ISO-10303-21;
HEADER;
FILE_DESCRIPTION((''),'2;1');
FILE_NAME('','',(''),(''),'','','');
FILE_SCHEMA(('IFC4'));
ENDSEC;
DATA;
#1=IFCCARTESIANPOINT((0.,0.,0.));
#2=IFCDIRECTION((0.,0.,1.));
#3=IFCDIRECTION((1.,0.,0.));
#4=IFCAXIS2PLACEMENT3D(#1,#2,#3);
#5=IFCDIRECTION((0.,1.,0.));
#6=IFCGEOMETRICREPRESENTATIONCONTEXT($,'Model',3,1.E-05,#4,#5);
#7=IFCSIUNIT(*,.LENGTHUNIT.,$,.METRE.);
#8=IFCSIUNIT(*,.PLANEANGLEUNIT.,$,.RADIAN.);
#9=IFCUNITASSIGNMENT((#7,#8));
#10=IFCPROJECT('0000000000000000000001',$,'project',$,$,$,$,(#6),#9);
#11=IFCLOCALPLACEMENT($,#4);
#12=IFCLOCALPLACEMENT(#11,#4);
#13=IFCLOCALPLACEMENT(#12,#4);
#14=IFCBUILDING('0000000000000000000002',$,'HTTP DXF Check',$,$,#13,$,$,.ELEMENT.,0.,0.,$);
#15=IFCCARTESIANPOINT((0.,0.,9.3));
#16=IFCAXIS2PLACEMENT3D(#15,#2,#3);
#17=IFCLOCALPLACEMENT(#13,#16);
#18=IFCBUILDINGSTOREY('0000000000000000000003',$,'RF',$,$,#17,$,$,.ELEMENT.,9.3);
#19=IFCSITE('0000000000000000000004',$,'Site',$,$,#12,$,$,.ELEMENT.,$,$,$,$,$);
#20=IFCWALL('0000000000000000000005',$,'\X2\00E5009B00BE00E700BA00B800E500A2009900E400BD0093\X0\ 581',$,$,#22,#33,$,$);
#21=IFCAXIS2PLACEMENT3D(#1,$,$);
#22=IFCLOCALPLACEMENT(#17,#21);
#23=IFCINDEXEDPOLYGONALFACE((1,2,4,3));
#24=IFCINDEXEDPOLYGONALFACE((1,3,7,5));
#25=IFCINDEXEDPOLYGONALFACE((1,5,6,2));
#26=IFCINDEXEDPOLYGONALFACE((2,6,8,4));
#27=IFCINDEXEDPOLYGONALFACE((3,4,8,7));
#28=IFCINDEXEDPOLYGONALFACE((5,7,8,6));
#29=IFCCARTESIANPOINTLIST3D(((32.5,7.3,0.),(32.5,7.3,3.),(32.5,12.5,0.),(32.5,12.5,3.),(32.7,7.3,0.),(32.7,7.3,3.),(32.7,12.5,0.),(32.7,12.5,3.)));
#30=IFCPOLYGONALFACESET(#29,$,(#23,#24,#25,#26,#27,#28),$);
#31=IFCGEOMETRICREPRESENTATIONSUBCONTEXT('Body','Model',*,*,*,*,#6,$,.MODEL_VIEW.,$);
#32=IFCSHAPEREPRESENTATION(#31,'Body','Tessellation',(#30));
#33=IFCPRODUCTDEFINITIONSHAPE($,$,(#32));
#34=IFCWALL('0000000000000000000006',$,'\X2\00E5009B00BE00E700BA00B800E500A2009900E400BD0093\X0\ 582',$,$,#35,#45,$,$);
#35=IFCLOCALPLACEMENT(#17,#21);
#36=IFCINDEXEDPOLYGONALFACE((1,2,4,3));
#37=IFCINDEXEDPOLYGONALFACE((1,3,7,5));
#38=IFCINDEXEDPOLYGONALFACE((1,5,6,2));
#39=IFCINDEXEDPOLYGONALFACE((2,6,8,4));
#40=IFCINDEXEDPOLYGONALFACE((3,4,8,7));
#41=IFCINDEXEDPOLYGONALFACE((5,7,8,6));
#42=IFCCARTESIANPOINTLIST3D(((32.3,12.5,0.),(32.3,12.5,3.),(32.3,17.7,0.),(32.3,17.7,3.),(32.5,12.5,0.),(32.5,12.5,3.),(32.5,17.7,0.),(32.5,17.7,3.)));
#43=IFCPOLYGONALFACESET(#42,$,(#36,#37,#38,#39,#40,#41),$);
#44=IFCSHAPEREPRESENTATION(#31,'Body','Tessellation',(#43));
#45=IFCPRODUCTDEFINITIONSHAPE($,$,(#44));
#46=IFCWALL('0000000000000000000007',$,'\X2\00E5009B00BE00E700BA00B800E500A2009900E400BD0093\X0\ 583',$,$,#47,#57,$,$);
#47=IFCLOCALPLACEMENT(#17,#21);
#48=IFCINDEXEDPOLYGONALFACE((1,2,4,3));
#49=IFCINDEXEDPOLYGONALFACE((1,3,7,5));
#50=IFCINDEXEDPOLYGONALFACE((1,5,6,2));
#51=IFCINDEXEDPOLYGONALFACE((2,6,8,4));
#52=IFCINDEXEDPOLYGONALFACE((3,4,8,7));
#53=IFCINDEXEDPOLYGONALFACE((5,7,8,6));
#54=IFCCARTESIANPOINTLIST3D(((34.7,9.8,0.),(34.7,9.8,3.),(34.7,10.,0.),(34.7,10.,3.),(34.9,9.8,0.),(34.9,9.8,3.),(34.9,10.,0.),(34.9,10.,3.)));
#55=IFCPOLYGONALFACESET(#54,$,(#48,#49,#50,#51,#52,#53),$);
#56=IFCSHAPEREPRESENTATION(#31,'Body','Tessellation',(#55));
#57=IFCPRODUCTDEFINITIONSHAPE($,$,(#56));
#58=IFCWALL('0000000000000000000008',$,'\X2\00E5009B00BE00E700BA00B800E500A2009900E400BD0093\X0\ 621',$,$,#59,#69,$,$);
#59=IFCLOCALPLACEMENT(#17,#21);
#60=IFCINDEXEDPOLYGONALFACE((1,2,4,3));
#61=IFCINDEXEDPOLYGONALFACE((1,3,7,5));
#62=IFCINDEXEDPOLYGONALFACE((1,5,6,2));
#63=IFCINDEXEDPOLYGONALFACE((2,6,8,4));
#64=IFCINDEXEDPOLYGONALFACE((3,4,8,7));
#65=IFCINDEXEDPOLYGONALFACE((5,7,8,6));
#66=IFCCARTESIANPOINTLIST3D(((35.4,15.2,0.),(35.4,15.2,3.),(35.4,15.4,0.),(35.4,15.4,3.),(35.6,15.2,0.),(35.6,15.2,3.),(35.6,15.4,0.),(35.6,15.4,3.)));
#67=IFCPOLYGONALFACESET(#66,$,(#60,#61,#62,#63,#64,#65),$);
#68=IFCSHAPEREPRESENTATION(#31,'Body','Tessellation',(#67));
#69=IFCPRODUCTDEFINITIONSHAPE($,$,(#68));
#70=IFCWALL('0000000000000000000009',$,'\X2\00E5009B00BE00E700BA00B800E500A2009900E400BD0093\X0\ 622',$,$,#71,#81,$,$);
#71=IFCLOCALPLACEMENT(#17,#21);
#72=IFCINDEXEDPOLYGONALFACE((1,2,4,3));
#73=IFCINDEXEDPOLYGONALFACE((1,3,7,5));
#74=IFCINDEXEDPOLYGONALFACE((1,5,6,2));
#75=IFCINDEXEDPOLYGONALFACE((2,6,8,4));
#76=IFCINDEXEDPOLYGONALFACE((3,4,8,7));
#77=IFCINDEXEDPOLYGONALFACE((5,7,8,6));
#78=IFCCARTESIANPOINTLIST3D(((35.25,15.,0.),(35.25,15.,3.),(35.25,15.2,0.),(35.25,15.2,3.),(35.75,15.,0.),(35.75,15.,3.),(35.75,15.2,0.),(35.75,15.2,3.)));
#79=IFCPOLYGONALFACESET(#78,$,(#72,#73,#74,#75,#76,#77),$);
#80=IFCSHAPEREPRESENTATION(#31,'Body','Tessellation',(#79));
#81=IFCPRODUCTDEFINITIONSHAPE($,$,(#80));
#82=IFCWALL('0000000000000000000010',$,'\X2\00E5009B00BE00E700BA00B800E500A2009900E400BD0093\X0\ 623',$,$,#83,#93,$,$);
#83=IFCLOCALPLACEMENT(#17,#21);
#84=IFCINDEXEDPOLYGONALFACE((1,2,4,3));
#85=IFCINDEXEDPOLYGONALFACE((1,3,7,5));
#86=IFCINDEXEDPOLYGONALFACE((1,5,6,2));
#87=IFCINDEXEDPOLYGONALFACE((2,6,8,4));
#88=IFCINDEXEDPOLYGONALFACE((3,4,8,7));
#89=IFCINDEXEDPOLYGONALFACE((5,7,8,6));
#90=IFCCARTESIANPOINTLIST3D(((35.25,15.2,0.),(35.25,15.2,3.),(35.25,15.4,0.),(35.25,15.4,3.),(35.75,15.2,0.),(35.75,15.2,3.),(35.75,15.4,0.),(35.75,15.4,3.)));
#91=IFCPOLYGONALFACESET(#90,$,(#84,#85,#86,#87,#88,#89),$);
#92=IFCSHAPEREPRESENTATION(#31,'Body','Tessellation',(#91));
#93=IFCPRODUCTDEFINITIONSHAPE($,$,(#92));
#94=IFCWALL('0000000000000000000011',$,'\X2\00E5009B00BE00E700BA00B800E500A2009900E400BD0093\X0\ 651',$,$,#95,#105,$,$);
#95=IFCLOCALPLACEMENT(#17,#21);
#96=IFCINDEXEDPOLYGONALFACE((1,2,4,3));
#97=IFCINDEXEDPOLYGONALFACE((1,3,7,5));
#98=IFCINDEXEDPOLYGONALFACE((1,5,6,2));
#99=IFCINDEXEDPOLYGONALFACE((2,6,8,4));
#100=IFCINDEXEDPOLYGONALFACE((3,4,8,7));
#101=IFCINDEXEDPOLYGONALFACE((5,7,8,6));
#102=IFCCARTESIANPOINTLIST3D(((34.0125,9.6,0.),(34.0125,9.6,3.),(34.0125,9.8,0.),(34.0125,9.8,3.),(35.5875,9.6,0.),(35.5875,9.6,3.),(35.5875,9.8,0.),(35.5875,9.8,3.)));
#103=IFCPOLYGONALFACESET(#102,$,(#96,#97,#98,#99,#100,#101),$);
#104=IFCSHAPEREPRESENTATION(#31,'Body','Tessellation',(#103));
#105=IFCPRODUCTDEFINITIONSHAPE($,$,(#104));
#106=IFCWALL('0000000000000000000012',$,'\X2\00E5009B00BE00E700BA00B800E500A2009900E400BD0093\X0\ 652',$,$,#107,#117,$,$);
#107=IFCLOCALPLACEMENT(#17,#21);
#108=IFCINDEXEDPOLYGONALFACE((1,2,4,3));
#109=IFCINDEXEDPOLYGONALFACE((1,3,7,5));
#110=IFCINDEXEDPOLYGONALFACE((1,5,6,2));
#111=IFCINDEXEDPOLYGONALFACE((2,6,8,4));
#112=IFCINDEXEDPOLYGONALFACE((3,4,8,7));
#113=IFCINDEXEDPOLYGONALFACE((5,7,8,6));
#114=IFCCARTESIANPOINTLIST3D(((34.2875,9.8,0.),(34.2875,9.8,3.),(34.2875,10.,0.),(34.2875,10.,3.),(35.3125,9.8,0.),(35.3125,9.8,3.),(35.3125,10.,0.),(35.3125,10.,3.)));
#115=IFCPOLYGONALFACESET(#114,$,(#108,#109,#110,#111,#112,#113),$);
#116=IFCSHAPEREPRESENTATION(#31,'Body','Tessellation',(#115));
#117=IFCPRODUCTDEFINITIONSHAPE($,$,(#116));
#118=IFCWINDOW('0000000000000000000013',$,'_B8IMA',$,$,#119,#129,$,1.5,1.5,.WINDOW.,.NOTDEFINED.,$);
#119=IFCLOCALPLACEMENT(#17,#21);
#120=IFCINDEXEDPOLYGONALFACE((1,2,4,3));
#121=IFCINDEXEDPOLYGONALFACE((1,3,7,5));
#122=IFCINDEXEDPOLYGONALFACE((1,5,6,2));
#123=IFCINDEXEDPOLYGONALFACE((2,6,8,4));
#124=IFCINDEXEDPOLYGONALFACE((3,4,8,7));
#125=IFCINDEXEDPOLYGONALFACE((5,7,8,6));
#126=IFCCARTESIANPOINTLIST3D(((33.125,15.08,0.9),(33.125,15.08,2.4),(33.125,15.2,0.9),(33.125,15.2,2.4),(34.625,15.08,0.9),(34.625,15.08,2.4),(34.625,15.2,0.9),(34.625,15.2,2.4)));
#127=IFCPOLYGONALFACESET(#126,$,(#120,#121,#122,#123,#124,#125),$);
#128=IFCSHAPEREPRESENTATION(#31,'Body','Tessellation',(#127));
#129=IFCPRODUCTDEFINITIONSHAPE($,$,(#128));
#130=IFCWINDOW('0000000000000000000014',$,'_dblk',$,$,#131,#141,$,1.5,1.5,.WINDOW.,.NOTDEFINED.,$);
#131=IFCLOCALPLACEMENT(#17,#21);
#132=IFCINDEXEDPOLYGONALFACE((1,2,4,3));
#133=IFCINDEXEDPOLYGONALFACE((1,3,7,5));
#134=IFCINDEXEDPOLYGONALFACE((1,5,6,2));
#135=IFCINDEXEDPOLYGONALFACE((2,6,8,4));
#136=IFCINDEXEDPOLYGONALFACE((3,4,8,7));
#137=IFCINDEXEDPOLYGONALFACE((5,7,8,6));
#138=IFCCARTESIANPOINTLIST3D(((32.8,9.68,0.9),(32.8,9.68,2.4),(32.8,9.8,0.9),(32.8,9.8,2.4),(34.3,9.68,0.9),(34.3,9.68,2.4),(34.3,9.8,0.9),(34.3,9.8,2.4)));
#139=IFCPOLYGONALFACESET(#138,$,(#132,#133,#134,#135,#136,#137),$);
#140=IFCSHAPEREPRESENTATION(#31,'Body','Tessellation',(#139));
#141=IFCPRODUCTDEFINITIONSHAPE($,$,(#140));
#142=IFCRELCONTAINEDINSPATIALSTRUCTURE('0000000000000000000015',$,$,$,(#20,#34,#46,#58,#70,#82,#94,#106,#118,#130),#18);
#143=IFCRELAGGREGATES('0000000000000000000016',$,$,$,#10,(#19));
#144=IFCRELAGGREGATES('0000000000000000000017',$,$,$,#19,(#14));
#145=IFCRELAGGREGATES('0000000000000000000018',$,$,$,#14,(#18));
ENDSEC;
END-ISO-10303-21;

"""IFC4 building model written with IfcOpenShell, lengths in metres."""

from ifc_helpers import new_model, si_unit, direction, frame, frame_2d, origin_with_axes, place, context, subcontext, project, spatial, rectangle, extrude, element, save


model = new_model("IFC4")

# Units and contexts
model_context = context("Model", 3, precision=1e-05, world=origin_with_axes(), true_north=direction((0.0, 1.0, 0.0)))
body_context = subcontext(model_context, "Body", "Model", "MODEL_VIEW")
ifc_project = project(units=[si_unit("LENGTHUNIT", "METRE"), si_unit("PLANEANGLEUNIT", "RADIAN")], contexts=[model_context])

# Site, building, storey
placement = place(None, origin_with_axes())
site_placement = place(placement, origin_with_axes())
site = spatial("IfcSite", under=ifc_project, at=site_placement, Name="Site", CompositionType="ELEMENT")
building_placement = place(site_placement, origin_with_axes())
building = spatial("IfcBuilding", under=site, at=building_placement, Name="HTTP DXF Check", CompositionType="ELEMENT", ElevationOfRefHeight=0.0, ElevationOfTerrain=0.0)
storey_placement = place(building_placement, frame((0.0, 0.0, 9.3), z_axis=(0.0, 0.0, 1.0), x_axis=(1.0, 0.0, 0.0)))
storey = spatial("IfcBuildingStorey", under=building, at=storey_placement, Name="RF", CompositionType="ELEMENT", Elevation=9.3)

# Walls
for number, where, z_axis, x_axis, name in (
    (1, (32.6, 9.9, 0.0), (0.0, 0.0, 1.0), (0.0, 1.0, 0.0), "å\u009b¾çº¸å¢\u0099ä½\u0093 581"),
    (2, (32.4, 15.1, 0.0), (0.0, 0.0, 1.0), (0.0, -1.0, 0.0), "å\u009b¾çº¸å¢\u0099ä½\u0093 582"),
):
    element("IfcWall", number, at=place(storey_placement, frame(where, z_axis=z_axis, x_axis=x_axis)), inside=storey, Name=name, context=body_context, shape_type="SweptSolid", body=[
        extrude(rectangle(XDim=5.2, YDim=0.2, at=frame_2d((0.0, 0.0), x_axis=(1.0, 0.0, 0.0))), frame((0.0, 0.0, 0.0), z_axis=(0.0, 0.0, 1.0)), (0.0, 0.0, 1.0), 3.0),
    ])
for number, where, z_axis, x_axis, name in (
    (3, (34.8, 9.9, 0.0), (0.0, 0.0, 1.0), (0.0, -1.0, 0.0), "å\u009b¾çº¸å¢\u0099ä½\u0093 583"),
    (4, (35.5, 15.3, 0.0), (0.0, 0.0, 1.0), (0.0, -1.0, 0.0), "å\u009b¾çº¸å¢\u0099ä½\u0093 621"),
):
    element("IfcWall", number, at=place(storey_placement, frame(where, z_axis=z_axis, x_axis=x_axis)), inside=storey, Name=name, context=body_context, shape_type="SweptSolid", body=[
        extrude(rectangle(XDim=0.2, YDim=0.2, at=frame_2d((0.0, 0.0), x_axis=(1.0, 0.0, 0.0))), frame((0.0, 0.0, 0.0), z_axis=(0.0, 0.0, 1.0)), (0.0, 0.0, 1.0), 3.0),
    ])
for number, where, z_axis, x_axis, name in (
    (5, (35.5, 15.1, 0.0), (0.0, 0.0, 1.0), (1.0, 0.0, 0.0), "å\u009b¾çº¸å¢\u0099ä½\u0093 622"),
    (6, (35.5, 15.3, 0.0), (0.0, 0.0, 1.0), (1.0, 0.0, 0.0), "å\u009b¾çº¸å¢\u0099ä½\u0093 623"),
):
    element("IfcWall", number, at=place(storey_placement, frame(where, z_axis=z_axis, x_axis=x_axis)), inside=storey, Name=name, context=body_context, shape_type="SweptSolid", body=[
        extrude(rectangle(XDim=0.5, YDim=0.2, at=frame_2d((0.0, 0.0), x_axis=(1.0, 0.0, 0.0))), frame((0.0, 0.0, 0.0), z_axis=(0.0, 0.0, 1.0)), (0.0, 0.0, 1.0), 3.0),
    ])
wall_1_placement = place(storey_placement, frame((34.8, 9.7, 0.0), z_axis=(0.0, 0.0, 1.0), x_axis=(1.0, 0.0, 0.0)))
element("IfcWall", 7, at=wall_1_placement, inside=storey, Name="å\u009b¾çº¸å¢\u0099ä½\u0093 651", context=body_context, shape_type="SweptSolid", body=[
    extrude(rectangle(XDim=1.575, YDim=0.2, at=frame_2d((0.0, 0.0), x_axis=(1.0, 0.0, 0.0))), frame((0.0, 0.0, 0.0), z_axis=(0.0, 0.0, 1.0)), (0.0, 0.0, 1.0), 3.0),
])
wall_2_placement = place(storey_placement, frame((34.8, 9.9, 0.0), z_axis=(0.0, 0.0, 1.0), x_axis=(1.0, 0.0, 0.0)))
element("IfcWall", 8, at=wall_2_placement, inside=storey, Name="å\u009b¾çº¸å¢\u0099ä½\u0093 652", context=body_context, shape_type="SweptSolid", body=[
    extrude(rectangle(XDim=1.025, YDim=0.2, at=frame_2d((0.0, 0.0), x_axis=(1.0, 0.0, 0.0))), frame((0.0, 0.0, 0.0), z_axis=(0.0, 0.0, 1.0)), (0.0, 0.0, 1.0), 3.0),
])

# Windows
for number, where, z_axis, x_axis, name in (
    (9, (33.875, 15.14, 0.9), (0.0, 0.0, 1.0), (1.0, 0.0, 0.0), "_B8IMA"),
    (10, (33.55, 9.74, 0.9), (0.0, 0.0, 1.0), (1.0, 0.0, 0.0), "_dblk"),
):
    element("IfcWindow", number, at=place(storey_placement, frame(where, z_axis=z_axis, x_axis=x_axis)), inside=storey, Name=name, OverallHeight=1.5, OverallWidth=1.5, PartitioningType="NOTDEFINED", PredefinedType="WINDOW", context=body_context, shape_type="SweptSolid", body=[
        extrude(rectangle(XDim=1.5, YDim=0.12, at=frame_2d((0.0, 0.0), x_axis=(1.0, 0.0, 0.0))), frame((0.0, 0.0, 0.0), z_axis=(0.0, 0.0, 1.0)), (0.0, 0.0, 1.0), 1.5),
    ])

save(model, "model.ifc")
